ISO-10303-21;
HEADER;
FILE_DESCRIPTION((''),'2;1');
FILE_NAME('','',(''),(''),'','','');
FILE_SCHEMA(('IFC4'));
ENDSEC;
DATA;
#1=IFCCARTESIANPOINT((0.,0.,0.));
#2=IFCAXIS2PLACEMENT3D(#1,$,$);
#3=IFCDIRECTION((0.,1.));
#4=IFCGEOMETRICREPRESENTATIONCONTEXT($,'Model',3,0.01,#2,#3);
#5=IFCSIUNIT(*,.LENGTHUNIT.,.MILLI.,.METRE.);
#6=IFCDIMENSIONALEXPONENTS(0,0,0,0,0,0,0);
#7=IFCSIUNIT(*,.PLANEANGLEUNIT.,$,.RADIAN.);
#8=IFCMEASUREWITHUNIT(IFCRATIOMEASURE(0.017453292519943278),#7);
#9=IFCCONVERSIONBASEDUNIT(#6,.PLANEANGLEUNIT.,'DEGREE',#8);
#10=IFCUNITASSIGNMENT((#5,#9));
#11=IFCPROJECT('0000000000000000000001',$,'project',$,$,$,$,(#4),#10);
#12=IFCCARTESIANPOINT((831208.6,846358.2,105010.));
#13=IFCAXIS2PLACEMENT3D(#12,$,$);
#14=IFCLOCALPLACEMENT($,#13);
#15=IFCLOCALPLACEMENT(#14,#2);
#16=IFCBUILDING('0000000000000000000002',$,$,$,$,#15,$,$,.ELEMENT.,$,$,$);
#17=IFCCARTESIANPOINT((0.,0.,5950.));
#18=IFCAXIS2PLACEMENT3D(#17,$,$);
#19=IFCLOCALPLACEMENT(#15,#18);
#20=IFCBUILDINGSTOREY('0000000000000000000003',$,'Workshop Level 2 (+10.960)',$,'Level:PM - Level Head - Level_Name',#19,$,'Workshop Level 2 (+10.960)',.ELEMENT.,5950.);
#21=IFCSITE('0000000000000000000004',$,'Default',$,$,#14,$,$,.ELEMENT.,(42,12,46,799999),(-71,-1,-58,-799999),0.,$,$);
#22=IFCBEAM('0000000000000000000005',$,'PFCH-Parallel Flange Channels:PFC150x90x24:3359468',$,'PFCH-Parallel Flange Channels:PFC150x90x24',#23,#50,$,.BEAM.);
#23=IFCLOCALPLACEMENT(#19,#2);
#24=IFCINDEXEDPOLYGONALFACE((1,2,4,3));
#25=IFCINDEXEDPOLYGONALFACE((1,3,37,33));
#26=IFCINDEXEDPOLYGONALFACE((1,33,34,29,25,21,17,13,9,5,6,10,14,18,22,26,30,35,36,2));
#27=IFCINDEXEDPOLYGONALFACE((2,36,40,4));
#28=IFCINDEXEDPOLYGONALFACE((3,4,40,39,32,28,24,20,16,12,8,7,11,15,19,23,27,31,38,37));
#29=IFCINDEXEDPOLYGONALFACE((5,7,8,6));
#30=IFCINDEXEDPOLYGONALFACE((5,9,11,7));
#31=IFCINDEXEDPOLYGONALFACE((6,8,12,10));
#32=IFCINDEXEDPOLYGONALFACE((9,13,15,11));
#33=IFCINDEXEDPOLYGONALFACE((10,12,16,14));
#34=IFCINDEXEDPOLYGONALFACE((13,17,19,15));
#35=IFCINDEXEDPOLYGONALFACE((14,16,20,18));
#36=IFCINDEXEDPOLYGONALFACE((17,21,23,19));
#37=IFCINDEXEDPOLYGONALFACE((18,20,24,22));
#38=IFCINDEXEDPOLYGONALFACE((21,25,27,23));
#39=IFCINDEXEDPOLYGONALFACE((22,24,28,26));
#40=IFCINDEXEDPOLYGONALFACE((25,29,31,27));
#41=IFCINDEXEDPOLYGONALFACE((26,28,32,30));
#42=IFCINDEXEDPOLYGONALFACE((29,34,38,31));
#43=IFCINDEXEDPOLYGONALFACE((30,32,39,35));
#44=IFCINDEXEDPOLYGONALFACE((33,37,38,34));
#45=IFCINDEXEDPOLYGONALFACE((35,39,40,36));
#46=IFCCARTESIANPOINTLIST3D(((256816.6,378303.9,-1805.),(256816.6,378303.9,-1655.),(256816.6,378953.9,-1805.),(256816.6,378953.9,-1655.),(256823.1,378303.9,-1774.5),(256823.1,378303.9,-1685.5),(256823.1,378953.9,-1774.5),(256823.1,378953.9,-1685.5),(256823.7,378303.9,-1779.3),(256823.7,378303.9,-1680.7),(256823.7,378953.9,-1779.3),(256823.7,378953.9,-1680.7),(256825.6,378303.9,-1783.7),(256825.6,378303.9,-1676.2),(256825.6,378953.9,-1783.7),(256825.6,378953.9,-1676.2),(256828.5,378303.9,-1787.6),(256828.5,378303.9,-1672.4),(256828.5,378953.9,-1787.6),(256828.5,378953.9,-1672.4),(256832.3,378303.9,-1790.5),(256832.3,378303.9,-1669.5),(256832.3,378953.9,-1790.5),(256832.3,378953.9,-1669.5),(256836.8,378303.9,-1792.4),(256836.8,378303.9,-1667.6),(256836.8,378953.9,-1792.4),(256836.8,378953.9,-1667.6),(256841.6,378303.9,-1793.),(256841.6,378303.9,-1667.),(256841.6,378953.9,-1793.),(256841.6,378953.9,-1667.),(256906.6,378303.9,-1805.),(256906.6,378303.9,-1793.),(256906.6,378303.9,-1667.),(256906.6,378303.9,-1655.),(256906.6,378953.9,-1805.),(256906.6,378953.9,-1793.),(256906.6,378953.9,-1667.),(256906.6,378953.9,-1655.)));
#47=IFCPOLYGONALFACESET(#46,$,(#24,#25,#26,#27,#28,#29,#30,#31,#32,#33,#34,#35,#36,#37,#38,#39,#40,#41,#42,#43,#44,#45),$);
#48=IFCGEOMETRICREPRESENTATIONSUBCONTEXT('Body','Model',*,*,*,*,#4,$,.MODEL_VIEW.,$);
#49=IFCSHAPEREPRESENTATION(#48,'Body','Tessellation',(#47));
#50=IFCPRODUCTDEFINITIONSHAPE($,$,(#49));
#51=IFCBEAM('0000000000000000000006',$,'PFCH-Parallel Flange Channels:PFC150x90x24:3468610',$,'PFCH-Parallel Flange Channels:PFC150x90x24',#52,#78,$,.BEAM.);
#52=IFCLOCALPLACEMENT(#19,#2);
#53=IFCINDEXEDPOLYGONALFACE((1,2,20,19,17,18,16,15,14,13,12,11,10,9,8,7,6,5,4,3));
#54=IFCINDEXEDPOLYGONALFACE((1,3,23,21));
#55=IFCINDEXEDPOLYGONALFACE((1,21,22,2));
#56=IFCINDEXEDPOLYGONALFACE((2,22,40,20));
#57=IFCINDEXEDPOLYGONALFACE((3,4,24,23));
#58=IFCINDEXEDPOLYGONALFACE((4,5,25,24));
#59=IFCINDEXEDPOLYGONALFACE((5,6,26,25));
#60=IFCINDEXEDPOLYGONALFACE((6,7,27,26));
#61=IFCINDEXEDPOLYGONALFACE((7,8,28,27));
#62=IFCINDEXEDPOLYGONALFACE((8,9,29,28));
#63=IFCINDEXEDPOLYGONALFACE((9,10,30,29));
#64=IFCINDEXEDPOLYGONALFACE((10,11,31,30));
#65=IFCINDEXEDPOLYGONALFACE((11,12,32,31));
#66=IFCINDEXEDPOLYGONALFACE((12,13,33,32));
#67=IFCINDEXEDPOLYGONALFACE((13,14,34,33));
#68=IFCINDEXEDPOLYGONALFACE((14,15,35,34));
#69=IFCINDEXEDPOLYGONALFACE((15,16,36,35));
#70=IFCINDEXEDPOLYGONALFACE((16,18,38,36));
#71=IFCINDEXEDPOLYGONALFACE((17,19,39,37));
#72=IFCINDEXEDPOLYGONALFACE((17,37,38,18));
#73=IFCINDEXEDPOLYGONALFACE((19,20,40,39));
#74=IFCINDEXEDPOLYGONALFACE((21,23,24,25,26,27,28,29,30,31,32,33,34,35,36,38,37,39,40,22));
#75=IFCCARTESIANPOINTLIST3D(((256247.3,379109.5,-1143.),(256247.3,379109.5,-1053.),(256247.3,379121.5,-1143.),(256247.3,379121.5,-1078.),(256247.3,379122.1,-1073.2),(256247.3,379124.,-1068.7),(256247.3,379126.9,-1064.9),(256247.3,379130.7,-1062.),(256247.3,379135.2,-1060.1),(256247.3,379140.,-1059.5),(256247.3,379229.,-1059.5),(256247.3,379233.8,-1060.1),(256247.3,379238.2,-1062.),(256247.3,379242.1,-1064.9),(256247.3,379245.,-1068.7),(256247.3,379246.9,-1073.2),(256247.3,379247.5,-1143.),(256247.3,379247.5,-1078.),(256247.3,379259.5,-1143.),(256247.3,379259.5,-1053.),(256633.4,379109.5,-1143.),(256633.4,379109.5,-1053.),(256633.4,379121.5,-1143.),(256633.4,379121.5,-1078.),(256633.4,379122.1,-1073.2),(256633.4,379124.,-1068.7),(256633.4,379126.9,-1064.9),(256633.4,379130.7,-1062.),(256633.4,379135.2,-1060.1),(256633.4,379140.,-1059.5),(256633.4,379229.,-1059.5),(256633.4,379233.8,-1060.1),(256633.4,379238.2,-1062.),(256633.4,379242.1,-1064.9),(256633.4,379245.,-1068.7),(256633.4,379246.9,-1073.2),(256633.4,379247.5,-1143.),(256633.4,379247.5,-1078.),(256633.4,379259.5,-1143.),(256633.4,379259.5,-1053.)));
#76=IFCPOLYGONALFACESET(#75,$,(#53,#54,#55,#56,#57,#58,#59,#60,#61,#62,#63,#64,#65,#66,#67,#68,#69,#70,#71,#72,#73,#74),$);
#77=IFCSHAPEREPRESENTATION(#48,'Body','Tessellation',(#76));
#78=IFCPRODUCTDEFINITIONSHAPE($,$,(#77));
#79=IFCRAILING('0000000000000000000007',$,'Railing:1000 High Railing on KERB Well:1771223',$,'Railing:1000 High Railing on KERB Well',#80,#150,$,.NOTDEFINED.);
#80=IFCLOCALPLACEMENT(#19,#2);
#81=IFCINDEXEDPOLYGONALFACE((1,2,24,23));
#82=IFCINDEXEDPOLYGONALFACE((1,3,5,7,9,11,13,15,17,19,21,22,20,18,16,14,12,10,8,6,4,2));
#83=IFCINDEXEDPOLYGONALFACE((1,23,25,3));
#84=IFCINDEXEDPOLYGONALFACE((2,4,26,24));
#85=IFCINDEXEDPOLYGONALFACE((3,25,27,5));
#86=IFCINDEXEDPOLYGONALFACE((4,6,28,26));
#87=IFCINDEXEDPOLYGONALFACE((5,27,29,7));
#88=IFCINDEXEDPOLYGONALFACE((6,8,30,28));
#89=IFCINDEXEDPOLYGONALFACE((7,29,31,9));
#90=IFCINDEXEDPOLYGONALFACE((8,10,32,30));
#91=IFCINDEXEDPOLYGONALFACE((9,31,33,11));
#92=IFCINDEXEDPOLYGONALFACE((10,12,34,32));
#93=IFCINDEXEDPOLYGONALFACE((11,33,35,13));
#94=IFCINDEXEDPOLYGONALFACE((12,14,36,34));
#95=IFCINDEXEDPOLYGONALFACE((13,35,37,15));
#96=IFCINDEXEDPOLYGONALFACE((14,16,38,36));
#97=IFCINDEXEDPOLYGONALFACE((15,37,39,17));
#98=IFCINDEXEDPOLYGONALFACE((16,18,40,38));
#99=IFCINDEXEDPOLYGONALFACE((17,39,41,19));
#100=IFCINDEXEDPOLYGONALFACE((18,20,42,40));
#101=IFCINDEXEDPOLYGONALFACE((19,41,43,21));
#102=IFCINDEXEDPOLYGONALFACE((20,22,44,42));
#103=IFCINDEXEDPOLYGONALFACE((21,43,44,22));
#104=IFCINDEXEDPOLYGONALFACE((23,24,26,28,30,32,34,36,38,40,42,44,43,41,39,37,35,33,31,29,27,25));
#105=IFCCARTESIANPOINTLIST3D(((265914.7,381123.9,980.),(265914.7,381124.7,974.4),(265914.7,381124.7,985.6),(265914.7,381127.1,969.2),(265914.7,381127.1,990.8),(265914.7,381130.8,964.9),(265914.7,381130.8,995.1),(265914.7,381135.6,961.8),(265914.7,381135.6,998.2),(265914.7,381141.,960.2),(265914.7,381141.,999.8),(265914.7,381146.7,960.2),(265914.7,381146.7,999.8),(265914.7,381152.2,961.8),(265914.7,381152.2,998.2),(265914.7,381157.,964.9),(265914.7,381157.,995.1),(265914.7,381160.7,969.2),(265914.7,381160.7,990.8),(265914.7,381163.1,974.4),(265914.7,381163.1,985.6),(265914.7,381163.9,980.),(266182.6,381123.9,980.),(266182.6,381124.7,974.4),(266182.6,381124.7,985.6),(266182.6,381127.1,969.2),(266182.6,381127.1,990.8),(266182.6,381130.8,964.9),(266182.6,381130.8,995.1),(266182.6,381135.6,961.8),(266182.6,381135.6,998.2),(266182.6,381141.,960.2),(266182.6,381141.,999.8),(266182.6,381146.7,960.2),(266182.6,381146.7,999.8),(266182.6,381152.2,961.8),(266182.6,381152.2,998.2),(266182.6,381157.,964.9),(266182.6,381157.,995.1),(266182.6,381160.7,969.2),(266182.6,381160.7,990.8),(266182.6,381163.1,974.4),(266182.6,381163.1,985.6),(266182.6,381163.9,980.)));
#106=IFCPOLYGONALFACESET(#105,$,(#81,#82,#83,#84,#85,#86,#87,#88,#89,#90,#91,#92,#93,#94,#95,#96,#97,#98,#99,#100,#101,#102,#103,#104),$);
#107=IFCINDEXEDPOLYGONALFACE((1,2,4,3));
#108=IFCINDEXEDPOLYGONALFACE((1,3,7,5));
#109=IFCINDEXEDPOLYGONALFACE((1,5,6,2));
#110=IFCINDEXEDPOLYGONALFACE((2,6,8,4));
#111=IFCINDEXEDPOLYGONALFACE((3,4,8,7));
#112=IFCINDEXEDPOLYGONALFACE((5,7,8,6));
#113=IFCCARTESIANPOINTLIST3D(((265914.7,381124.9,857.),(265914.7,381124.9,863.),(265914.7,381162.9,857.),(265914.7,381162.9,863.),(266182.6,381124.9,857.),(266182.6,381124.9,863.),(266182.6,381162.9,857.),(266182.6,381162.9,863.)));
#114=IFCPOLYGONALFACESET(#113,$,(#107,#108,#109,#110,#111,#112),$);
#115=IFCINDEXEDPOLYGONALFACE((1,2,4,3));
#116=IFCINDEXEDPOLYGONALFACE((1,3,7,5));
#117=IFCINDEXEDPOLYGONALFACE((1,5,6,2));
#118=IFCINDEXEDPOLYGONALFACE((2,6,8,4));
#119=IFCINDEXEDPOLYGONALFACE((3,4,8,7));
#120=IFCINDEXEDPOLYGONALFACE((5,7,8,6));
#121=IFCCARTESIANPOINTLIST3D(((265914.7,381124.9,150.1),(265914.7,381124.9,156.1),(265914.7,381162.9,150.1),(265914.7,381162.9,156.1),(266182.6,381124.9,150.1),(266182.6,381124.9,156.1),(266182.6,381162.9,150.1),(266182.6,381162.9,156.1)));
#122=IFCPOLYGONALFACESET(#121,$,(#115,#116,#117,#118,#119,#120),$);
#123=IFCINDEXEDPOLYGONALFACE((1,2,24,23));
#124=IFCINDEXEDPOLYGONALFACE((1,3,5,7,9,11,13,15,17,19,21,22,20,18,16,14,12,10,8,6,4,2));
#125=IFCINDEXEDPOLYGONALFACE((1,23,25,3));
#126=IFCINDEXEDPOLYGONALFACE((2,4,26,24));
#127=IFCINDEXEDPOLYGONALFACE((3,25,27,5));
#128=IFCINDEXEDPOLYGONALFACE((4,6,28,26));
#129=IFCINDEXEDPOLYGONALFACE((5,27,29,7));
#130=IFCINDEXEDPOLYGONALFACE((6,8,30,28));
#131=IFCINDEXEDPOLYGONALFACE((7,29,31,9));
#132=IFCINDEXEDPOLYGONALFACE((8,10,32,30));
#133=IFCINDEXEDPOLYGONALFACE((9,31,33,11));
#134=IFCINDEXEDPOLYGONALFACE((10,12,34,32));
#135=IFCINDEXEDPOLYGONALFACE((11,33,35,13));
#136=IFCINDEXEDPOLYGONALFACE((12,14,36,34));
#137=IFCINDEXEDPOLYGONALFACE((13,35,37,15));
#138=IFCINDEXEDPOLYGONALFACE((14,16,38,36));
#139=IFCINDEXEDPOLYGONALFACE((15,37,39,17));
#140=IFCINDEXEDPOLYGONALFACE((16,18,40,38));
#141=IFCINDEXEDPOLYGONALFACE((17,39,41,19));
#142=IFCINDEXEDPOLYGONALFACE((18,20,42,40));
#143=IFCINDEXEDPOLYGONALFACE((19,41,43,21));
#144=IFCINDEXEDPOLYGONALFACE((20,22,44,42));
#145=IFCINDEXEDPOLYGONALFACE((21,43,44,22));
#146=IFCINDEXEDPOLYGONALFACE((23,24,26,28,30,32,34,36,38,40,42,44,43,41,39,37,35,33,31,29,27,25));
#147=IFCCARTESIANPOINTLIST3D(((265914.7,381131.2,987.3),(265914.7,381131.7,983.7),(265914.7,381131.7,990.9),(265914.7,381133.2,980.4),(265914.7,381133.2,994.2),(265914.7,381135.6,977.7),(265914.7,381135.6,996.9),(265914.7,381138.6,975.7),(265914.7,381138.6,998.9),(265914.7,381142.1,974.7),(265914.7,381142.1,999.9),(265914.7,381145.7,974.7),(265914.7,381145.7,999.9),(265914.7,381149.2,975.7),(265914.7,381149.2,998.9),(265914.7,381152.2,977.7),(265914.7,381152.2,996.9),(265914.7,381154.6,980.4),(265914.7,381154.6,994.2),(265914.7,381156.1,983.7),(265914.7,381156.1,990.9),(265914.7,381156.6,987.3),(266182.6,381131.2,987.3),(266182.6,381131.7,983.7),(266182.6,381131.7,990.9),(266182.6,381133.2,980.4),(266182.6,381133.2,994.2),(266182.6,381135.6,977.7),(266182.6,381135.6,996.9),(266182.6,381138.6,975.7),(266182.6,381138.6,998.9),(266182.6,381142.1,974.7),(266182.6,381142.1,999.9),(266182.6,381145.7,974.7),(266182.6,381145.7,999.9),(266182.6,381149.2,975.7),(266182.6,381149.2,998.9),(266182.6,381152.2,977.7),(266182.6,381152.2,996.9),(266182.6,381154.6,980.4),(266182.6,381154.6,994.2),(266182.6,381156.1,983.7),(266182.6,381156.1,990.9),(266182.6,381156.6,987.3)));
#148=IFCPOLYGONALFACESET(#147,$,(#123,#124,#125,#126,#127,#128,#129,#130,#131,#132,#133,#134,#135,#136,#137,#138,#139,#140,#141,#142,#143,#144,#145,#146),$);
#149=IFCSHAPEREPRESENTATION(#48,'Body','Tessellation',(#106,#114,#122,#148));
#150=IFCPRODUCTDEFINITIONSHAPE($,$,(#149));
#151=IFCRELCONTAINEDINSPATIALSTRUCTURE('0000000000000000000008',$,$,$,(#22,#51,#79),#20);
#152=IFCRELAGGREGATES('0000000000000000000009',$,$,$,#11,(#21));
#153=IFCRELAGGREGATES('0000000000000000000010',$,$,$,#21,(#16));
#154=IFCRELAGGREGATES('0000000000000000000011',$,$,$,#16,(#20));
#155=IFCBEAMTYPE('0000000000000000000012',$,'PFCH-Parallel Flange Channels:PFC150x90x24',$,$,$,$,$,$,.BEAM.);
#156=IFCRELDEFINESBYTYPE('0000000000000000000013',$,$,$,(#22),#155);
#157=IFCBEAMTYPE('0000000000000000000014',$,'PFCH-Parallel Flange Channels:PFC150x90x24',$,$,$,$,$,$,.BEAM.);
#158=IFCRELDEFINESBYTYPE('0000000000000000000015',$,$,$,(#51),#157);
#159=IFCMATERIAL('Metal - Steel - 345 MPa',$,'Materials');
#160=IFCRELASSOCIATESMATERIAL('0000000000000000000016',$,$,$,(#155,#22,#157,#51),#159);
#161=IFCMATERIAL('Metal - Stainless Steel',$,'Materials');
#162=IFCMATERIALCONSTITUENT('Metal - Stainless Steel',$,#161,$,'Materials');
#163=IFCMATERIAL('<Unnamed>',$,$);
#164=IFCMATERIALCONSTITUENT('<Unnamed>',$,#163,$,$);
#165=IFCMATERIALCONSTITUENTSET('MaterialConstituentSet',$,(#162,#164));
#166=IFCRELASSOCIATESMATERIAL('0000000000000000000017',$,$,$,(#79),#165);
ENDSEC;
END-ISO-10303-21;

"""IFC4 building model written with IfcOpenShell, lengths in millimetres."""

from ifc_helpers import new_model, entity, si_unit, converted_unit, direction, frame, origin, place, context, subcontext, project, spatial, line, arc, indexed_curve, outline, extrude, source, transform, mapped, material, constituent, constituent_set, type_object, type_shapes, element, save


model = new_model("IFC4")

# Units and contexts
model_context = context("Model", 3, precision=0.01, world=origin(), true_north=direction((0.0, 1.0)))
body_context = subcontext(model_context, "Body", "Model", "MODEL_VIEW")
ifc_project = project(units=[si_unit("LENGTHUNIT", "METRE", prefix="MILLI"), converted_unit("PLANEANGLEUNIT", "DEGREE", entity("IfcRatioMeasure", 0.017453292519943278), si_unit("PLANEANGLEUNIT", "RADIAN"), dimensions=[0, 0, 0, 0, 0, 0, 0])], contexts=[model_context])

# Site, building, storey
site_placement = place(None, frame((831208.6, 846358.2, 105010.0)))
site = spatial("IfcSite", under=ifc_project, at=site_placement, Name="Default", CompositionType="ELEMENT", RefLatitude=(42, 12, 46, 799999), RefLongitude=(-71, -1, -58, -799999), RefElevation=0.0)
building_placement = place(site_placement, origin())
building = spatial("IfcBuilding", under=site, at=building_placement, CompositionType="ELEMENT")
storey_placement = place(building_placement, frame((0.0, 0.0, 5950.0)))
storey = spatial("IfcBuildingStorey", under=building, at=storey_placement, Name="Workshop Level 2 (+10.960)", ObjectType="Level:PM - Level Head - Level_Name", LongName="Workshop Level 2 (+10.960)", CompositionType="ELEMENT", Elevation=5950.0)

# Beams
ifc_material_1 = material(Name="Metal - Steel - 345 MPa", Category="Materials")
beam_type_1 = type_object("IfcBeamType", Name="PFCH-Parallel Flange Channels:PFC150x90x24", PredefinedType="BEAM", material=ifc_material_1)
shared_shape_1 = source(origin(), body_context, "Body", "SweptSolid", [
    extrude(outline(indexed_curve([(-75.0, -47.7), (-63.0, -47.7), (-63.0, 17.3), (-57.6, 30.4), (-44.5, 35.8), (44.5, 35.8), (57.6, 30.4), (63.0, 17.3), (63.0, -47.7), (75.0, -47.7), (75.0, 42.3), (-75.0, 42.3)], segments=[line(1, 2, 3), arc(3, 4, 5), line(5, 6), arc(6, 7, 8), line(8, 9, 10, 11, 12, 1)], self_intersect=False)), frame((-309.5, -9.3, 0.0), z_axis=(1.0, 0.0, 0.0), x_axis=(0.0, 0.0, -1.0)), (0.0, 0.0, 1.0), 650.0),
])
type_shapes(beam_type_1, [shared_shape_1])
beam_1_placement = place(storey_placement, frame((256849.6, 378613.4, -1730.0), z_axis=(0.0, 0.0, 1.0), x_axis=(0.0, 1.0, 0.0)))
element("IfcBeam", 1, at=beam_1_placement, inside=storey, type_object=beam_type_1, material=ifc_material_1, Name="PFCH-Parallel Flange Channels:PFC150x90x24:3359468", ObjectType="PFCH-Parallel Flange Channels:PFC150x90x24", PredefinedType="BEAM", context=body_context, shape_type="MappedRepresentation", body=[
    mapped(shared_shape_1, transform((0.0, 0.0, 0.0), scale=1.0)),
])
beam_type_2 = type_object("IfcBeamType", Name="PFCH-Parallel Flange Channels:PFC150x90x24", PredefinedType="BEAM", material=ifc_material_1)
shared_shape_2 = source(origin(), body_context, "Body", "SweptSolid", [
    extrude(outline(indexed_curve([(-75.0, -42.3), (75.0, -42.3), (75.0, 47.7), (63.0, 47.7), (63.0, -17.3), (57.6, -30.4), (44.5, -35.8), (-44.5, -35.8), (-57.6, -30.4), (-63.0, -17.3), (-63.0, 47.7), (-75.0, 47.7)], segments=[line(1, 2, 3, 4, 5), arc(5, 6, 7), line(7, 8), arc(8, 9, 10), line(10, 11, 12, 1)], self_intersect=False)), frame((-204.2, 9.3, 0.0), z_axis=(1.0, 0.0, 0.0), x_axis=(0.0, 0.0, -1.0)), (0.0, 0.0, 1.0), 386.1),
])
type_shapes(beam_type_2, [shared_shape_2])
beam_2_placement = place(storey_placement, frame((256451.5, 379184.5, -1086.0), z_axis=(0.0, 1.0, 0.0), x_axis=(1.0, 0.0, 0.0)))
element("IfcBeam", 2, at=beam_2_placement, inside=storey, type_object=beam_type_2, material=ifc_material_1, Name="PFCH-Parallel Flange Channels:PFC150x90x24:3468610", ObjectType="PFCH-Parallel Flange Channels:PFC150x90x24", PredefinedType="BEAM", context=body_context, shape_type="MappedRepresentation", body=[
    mapped(shared_shape_2, transform((0.0, 0.0, 0.0), scale=1.0)),
])

# Railing
ifc_material_2 = material(Name="Metal - Stainless Steel", Category="Materials")
ifc_constituent_1 = constituent(ifc_material_2, Name="Metal - Stainless Steel", Category="Materials")
ifc_material_3 = material(Name="<Unnamed>")
ifc_constituent_2 = constituent(ifc_material_3, Name="<Unnamed>")
ifc_constituent_set = constituent_set(constituents=[ifc_constituent_1, ifc_constituent_2], Name="MaterialConstituentSet")
railing_placement = place(storey_placement, origin())
element("IfcRailing", 3, at=railing_placement, inside=storey, material=ifc_constituent_set, Name="Railing:1000 High Railing on KERB Well:1771223", ObjectType="Railing:1000 High Railing on KERB Well", PredefinedType="NOTDEFINED", context=body_context, shape_type="SweptSolid", body=[
    extrude(outline(indexed_curve([(-20.0, 0.0), (0.0, -20.0), (20.0, 0.0), (0.0, 20.0)], segments=[arc(1, 2, 3), arc(3, 4, 1)], self_intersect=False)), frame((265914.7, 381143.9, 980.0), z_axis=(1.0, 0.0, 0.0), x_axis=(0.0, 1.0, 0.0)), (0.0, 0.0, 1.0), 267.9),
    extrude(outline(indexed_curve([(-134.0, -19.0), (134.0, -19.0), (134.0, 19.0), (-134.0, 19.0), (-134.0, -19.0)], self_intersect=False)), frame((266048.7, 381143.9, 857.0), z_axis=(0.0, 0.0, 1.0), x_axis=(-1.0, 0.0, 0.0)), (0.0, 0.0, 1.0), 6.0),
    extrude(outline(indexed_curve([(-134.0, -19.0), (134.0, -19.0), (134.0, 19.0), (-134.0, 19.0), (-134.0, -19.0)], self_intersect=False)), frame((266048.7, 381143.9, 150.1), z_axis=(0.0, 0.0, 1.0), x_axis=(-1.0, 0.0, 0.0)), (0.0, 0.0, 1.0), 6.0),
    extrude(outline(indexed_curve([(-12.7, 0.0), (0.0, -12.7), (12.7, 0.0), (0.0, 12.7)], segments=[arc(1, 2, 3), arc(3, 4, 1)], self_intersect=False)), frame((265914.7, 381143.9, 987.3), z_axis=(1.0, 0.0, 0.0), x_axis=(0.0, -1.0, 0.0)), (0.0, 0.0, 1.0), 267.9),
])

save(model, "model.ifc")
